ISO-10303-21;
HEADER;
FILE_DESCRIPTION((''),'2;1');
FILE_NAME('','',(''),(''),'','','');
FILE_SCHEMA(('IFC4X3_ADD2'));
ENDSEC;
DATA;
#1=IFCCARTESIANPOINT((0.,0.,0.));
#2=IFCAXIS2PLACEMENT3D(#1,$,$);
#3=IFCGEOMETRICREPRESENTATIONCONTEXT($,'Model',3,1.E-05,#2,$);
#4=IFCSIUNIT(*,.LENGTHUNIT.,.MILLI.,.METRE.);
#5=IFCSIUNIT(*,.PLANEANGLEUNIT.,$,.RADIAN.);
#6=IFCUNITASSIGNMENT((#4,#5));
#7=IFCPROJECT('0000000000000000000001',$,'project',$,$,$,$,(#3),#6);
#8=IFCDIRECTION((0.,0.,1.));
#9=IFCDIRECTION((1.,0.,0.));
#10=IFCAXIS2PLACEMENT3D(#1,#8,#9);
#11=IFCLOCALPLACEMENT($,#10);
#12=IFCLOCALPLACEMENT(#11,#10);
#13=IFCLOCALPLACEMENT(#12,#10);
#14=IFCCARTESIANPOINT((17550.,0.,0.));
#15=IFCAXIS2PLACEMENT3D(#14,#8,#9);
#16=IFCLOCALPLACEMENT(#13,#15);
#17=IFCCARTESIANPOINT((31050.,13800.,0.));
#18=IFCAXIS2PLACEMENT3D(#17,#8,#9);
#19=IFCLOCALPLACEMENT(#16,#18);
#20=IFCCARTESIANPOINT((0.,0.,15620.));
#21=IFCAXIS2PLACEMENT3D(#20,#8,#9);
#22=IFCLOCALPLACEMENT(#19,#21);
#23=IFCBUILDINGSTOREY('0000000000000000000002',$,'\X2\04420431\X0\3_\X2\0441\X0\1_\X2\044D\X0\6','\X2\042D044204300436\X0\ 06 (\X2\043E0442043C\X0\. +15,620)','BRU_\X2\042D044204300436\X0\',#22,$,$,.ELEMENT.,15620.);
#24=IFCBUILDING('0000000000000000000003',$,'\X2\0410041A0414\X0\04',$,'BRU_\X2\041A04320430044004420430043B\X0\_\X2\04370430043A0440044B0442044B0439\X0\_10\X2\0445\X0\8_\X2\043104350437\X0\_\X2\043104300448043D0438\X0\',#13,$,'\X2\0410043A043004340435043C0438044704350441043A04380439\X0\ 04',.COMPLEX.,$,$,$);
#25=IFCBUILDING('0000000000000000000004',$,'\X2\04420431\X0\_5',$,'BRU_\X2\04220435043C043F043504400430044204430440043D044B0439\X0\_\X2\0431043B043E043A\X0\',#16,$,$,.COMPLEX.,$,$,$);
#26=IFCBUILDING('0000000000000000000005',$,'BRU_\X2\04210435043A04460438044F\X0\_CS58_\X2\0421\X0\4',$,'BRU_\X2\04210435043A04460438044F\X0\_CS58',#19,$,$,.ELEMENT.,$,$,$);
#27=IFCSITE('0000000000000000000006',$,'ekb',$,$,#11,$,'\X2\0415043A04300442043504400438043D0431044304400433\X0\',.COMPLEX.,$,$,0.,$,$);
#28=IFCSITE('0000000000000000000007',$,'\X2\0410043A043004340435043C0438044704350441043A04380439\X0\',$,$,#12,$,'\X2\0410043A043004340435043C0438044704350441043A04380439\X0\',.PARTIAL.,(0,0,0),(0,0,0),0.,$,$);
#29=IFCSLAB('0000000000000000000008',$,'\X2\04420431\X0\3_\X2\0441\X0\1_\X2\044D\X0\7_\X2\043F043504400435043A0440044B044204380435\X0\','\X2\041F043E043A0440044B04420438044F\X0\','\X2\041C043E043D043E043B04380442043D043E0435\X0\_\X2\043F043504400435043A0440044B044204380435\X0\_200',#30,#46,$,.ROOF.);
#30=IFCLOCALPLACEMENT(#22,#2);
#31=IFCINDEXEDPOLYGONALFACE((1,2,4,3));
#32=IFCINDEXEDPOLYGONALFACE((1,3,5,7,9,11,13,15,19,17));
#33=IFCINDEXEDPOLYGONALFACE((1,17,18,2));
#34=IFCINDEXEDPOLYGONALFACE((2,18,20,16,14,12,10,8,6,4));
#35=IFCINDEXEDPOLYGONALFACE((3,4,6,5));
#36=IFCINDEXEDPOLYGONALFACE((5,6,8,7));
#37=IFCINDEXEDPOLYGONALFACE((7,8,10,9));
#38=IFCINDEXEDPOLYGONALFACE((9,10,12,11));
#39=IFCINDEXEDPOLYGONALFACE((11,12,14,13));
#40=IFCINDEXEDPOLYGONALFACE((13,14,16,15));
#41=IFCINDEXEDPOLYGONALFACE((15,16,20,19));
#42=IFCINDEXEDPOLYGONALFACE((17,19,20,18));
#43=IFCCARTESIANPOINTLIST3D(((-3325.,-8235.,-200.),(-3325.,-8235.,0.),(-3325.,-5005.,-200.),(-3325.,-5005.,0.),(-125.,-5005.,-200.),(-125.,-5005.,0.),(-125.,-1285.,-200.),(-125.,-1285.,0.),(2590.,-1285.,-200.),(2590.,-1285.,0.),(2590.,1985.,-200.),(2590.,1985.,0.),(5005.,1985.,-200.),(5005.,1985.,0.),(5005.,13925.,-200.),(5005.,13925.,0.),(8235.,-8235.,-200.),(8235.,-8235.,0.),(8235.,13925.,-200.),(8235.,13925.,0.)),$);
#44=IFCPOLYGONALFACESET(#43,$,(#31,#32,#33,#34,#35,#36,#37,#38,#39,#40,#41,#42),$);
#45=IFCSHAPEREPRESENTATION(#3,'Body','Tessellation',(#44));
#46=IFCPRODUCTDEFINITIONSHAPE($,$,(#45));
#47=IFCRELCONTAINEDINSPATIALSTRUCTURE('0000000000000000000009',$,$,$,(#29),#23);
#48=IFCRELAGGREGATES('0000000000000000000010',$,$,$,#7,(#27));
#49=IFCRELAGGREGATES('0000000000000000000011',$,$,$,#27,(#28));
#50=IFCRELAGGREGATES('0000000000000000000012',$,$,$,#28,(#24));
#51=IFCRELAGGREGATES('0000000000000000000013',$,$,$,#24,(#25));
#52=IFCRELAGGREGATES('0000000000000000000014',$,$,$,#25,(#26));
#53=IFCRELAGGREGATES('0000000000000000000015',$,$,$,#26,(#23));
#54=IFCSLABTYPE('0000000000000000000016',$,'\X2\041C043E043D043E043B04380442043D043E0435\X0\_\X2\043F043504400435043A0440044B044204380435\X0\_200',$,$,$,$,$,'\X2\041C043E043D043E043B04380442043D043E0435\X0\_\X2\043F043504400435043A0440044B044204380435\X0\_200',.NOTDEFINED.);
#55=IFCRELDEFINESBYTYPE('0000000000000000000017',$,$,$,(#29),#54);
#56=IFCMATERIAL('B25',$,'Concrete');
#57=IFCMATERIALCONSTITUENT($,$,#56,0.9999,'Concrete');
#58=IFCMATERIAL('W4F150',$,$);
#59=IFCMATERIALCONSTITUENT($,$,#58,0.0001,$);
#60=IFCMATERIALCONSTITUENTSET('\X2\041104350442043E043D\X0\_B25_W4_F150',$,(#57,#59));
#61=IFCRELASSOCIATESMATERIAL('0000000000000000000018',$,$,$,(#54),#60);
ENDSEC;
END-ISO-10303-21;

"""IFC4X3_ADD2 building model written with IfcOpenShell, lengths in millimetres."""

from ifc_helpers import new_model, si_unit, frame, origin, origin_with_axes, place, context, project, spatial, polyline, outline, extrude, material, constituent, constituent_set, type_object, element, save


model = new_model("IFC4X3_ADD2")

# Units and contexts
model_context = context("Model", 3, precision=1e-05, world=origin())
ifc_project = project(units=[si_unit("LENGTHUNIT", "METRE", prefix="MILLI"), si_unit("PLANEANGLEUNIT", "RADIAN")], contexts=[model_context])

# Sites, buildings, storey
site_1_placement = place(None, origin_with_axes())
site_1 = spatial("IfcSite", under=ifc_project, at=site_1_placement, Name="ekb", LongName="Екатеринбург", CompositionType="COMPLEX", RefElevation=0.0)
site_2_placement = place(site_1_placement, origin_with_axes())
site_2 = spatial("IfcSite", under=site_1, at=site_2_placement, Name="Академический", LongName="Академический", CompositionType="PARTIAL", RefLatitude=(0, 0, 0), RefLongitude=(0, 0, 0), RefElevation=0.0)
building_1_placement = place(site_2_placement, origin_with_axes())
building_1 = spatial("IfcBuilding", under=site_2, at=building_1_placement, Name="АКД04", ObjectType="BRU_Квартал_закрытый_10х8_без_башни", LongName="Академический 04", CompositionType="COMPLEX")
building_2_placement = place(building_1_placement, frame((17550.0, 0.0, 0.0), z_axis=(0.0, 0.0, 1.0), x_axis=(1.0, 0.0, 0.0)))
building_2 = spatial("IfcBuilding", under=building_1, at=building_2_placement, Name="тб_5", ObjectType="BRU_Температурный_блок", CompositionType="COMPLEX")
building_3_placement = place(building_2_placement, frame((31050.0, 13800.0, 0.0), z_axis=(0.0, 0.0, 1.0), x_axis=(1.0, 0.0, 0.0)))
building_3 = spatial("IfcBuilding", under=building_2, at=building_3_placement, Name="BRU_Секция_CS58_С4", ObjectType="BRU_Секция_CS58", CompositionType="ELEMENT")
storey_placement = place(building_3_placement, frame((0.0, 0.0, 15620.0), z_axis=(0.0, 0.0, 1.0), x_axis=(1.0, 0.0, 0.0)))
storey = spatial("IfcBuildingStorey", under=building_3, at=storey_placement, Name="тб3_с1_э6", Description="Этаж 06 (отм. +15,620)", ObjectType="BRU_Этаж", CompositionType="ELEMENT", Elevation=15620.0)

# Slab
ifc_material_1 = material(Name="B25", Category="Concrete")
ifc_constituent_1 = constituent(ifc_material_1, Category="Concrete", fraction=0.9999)
ifc_material_2 = material(Name="W4F150")
ifc_constituent_2 = constituent(ifc_material_2, fraction=0.0001)
ifc_constituent_set = constituent_set(constituents=[ifc_constituent_1, ifc_constituent_2], Name="Бетон_B25_W4_F150")
slab_type = type_object("IfcSlabType", Name="Монолитное_перекрытие_200", ElementType="Монолитное_перекрытие_200", PredefinedType="NOTDEFINED", material=ifc_constituent_set)
slab_placement = place(storey_placement, frame((0.0, 0.0, -200.0), z_axis=(0.0, 0.0, 1.0), x_axis=(1.0, 0.0, 0.0)))
element("IfcSlab", 1, at=slab_placement, inside=storey, type_object=slab_type, Name="тб3_с1_э7_перекрытие", Description="Покрытия", ObjectType="Монолитное_перекрытие_200", PredefinedType="ROOF", context=model_context, shape_type="SweptSolid", body=[
    extrude(outline(polyline([(8235.0, -8235.0), (8235.0, 13925.0), (5005.0, 13925.0), (5005.0, 1985.0), (2590.0, 1985.0), (2590.0, -1285.0), (-125.0, -1285.0), (-125.0, -5005.0), (-3325.0, -5005.0), (-3325.0, -8235.0), (8235.0, -8235.0)])), origin_with_axes(), (0.0, 0.0, 1.0), 200.0),
])

save(model, "model.ifc")
